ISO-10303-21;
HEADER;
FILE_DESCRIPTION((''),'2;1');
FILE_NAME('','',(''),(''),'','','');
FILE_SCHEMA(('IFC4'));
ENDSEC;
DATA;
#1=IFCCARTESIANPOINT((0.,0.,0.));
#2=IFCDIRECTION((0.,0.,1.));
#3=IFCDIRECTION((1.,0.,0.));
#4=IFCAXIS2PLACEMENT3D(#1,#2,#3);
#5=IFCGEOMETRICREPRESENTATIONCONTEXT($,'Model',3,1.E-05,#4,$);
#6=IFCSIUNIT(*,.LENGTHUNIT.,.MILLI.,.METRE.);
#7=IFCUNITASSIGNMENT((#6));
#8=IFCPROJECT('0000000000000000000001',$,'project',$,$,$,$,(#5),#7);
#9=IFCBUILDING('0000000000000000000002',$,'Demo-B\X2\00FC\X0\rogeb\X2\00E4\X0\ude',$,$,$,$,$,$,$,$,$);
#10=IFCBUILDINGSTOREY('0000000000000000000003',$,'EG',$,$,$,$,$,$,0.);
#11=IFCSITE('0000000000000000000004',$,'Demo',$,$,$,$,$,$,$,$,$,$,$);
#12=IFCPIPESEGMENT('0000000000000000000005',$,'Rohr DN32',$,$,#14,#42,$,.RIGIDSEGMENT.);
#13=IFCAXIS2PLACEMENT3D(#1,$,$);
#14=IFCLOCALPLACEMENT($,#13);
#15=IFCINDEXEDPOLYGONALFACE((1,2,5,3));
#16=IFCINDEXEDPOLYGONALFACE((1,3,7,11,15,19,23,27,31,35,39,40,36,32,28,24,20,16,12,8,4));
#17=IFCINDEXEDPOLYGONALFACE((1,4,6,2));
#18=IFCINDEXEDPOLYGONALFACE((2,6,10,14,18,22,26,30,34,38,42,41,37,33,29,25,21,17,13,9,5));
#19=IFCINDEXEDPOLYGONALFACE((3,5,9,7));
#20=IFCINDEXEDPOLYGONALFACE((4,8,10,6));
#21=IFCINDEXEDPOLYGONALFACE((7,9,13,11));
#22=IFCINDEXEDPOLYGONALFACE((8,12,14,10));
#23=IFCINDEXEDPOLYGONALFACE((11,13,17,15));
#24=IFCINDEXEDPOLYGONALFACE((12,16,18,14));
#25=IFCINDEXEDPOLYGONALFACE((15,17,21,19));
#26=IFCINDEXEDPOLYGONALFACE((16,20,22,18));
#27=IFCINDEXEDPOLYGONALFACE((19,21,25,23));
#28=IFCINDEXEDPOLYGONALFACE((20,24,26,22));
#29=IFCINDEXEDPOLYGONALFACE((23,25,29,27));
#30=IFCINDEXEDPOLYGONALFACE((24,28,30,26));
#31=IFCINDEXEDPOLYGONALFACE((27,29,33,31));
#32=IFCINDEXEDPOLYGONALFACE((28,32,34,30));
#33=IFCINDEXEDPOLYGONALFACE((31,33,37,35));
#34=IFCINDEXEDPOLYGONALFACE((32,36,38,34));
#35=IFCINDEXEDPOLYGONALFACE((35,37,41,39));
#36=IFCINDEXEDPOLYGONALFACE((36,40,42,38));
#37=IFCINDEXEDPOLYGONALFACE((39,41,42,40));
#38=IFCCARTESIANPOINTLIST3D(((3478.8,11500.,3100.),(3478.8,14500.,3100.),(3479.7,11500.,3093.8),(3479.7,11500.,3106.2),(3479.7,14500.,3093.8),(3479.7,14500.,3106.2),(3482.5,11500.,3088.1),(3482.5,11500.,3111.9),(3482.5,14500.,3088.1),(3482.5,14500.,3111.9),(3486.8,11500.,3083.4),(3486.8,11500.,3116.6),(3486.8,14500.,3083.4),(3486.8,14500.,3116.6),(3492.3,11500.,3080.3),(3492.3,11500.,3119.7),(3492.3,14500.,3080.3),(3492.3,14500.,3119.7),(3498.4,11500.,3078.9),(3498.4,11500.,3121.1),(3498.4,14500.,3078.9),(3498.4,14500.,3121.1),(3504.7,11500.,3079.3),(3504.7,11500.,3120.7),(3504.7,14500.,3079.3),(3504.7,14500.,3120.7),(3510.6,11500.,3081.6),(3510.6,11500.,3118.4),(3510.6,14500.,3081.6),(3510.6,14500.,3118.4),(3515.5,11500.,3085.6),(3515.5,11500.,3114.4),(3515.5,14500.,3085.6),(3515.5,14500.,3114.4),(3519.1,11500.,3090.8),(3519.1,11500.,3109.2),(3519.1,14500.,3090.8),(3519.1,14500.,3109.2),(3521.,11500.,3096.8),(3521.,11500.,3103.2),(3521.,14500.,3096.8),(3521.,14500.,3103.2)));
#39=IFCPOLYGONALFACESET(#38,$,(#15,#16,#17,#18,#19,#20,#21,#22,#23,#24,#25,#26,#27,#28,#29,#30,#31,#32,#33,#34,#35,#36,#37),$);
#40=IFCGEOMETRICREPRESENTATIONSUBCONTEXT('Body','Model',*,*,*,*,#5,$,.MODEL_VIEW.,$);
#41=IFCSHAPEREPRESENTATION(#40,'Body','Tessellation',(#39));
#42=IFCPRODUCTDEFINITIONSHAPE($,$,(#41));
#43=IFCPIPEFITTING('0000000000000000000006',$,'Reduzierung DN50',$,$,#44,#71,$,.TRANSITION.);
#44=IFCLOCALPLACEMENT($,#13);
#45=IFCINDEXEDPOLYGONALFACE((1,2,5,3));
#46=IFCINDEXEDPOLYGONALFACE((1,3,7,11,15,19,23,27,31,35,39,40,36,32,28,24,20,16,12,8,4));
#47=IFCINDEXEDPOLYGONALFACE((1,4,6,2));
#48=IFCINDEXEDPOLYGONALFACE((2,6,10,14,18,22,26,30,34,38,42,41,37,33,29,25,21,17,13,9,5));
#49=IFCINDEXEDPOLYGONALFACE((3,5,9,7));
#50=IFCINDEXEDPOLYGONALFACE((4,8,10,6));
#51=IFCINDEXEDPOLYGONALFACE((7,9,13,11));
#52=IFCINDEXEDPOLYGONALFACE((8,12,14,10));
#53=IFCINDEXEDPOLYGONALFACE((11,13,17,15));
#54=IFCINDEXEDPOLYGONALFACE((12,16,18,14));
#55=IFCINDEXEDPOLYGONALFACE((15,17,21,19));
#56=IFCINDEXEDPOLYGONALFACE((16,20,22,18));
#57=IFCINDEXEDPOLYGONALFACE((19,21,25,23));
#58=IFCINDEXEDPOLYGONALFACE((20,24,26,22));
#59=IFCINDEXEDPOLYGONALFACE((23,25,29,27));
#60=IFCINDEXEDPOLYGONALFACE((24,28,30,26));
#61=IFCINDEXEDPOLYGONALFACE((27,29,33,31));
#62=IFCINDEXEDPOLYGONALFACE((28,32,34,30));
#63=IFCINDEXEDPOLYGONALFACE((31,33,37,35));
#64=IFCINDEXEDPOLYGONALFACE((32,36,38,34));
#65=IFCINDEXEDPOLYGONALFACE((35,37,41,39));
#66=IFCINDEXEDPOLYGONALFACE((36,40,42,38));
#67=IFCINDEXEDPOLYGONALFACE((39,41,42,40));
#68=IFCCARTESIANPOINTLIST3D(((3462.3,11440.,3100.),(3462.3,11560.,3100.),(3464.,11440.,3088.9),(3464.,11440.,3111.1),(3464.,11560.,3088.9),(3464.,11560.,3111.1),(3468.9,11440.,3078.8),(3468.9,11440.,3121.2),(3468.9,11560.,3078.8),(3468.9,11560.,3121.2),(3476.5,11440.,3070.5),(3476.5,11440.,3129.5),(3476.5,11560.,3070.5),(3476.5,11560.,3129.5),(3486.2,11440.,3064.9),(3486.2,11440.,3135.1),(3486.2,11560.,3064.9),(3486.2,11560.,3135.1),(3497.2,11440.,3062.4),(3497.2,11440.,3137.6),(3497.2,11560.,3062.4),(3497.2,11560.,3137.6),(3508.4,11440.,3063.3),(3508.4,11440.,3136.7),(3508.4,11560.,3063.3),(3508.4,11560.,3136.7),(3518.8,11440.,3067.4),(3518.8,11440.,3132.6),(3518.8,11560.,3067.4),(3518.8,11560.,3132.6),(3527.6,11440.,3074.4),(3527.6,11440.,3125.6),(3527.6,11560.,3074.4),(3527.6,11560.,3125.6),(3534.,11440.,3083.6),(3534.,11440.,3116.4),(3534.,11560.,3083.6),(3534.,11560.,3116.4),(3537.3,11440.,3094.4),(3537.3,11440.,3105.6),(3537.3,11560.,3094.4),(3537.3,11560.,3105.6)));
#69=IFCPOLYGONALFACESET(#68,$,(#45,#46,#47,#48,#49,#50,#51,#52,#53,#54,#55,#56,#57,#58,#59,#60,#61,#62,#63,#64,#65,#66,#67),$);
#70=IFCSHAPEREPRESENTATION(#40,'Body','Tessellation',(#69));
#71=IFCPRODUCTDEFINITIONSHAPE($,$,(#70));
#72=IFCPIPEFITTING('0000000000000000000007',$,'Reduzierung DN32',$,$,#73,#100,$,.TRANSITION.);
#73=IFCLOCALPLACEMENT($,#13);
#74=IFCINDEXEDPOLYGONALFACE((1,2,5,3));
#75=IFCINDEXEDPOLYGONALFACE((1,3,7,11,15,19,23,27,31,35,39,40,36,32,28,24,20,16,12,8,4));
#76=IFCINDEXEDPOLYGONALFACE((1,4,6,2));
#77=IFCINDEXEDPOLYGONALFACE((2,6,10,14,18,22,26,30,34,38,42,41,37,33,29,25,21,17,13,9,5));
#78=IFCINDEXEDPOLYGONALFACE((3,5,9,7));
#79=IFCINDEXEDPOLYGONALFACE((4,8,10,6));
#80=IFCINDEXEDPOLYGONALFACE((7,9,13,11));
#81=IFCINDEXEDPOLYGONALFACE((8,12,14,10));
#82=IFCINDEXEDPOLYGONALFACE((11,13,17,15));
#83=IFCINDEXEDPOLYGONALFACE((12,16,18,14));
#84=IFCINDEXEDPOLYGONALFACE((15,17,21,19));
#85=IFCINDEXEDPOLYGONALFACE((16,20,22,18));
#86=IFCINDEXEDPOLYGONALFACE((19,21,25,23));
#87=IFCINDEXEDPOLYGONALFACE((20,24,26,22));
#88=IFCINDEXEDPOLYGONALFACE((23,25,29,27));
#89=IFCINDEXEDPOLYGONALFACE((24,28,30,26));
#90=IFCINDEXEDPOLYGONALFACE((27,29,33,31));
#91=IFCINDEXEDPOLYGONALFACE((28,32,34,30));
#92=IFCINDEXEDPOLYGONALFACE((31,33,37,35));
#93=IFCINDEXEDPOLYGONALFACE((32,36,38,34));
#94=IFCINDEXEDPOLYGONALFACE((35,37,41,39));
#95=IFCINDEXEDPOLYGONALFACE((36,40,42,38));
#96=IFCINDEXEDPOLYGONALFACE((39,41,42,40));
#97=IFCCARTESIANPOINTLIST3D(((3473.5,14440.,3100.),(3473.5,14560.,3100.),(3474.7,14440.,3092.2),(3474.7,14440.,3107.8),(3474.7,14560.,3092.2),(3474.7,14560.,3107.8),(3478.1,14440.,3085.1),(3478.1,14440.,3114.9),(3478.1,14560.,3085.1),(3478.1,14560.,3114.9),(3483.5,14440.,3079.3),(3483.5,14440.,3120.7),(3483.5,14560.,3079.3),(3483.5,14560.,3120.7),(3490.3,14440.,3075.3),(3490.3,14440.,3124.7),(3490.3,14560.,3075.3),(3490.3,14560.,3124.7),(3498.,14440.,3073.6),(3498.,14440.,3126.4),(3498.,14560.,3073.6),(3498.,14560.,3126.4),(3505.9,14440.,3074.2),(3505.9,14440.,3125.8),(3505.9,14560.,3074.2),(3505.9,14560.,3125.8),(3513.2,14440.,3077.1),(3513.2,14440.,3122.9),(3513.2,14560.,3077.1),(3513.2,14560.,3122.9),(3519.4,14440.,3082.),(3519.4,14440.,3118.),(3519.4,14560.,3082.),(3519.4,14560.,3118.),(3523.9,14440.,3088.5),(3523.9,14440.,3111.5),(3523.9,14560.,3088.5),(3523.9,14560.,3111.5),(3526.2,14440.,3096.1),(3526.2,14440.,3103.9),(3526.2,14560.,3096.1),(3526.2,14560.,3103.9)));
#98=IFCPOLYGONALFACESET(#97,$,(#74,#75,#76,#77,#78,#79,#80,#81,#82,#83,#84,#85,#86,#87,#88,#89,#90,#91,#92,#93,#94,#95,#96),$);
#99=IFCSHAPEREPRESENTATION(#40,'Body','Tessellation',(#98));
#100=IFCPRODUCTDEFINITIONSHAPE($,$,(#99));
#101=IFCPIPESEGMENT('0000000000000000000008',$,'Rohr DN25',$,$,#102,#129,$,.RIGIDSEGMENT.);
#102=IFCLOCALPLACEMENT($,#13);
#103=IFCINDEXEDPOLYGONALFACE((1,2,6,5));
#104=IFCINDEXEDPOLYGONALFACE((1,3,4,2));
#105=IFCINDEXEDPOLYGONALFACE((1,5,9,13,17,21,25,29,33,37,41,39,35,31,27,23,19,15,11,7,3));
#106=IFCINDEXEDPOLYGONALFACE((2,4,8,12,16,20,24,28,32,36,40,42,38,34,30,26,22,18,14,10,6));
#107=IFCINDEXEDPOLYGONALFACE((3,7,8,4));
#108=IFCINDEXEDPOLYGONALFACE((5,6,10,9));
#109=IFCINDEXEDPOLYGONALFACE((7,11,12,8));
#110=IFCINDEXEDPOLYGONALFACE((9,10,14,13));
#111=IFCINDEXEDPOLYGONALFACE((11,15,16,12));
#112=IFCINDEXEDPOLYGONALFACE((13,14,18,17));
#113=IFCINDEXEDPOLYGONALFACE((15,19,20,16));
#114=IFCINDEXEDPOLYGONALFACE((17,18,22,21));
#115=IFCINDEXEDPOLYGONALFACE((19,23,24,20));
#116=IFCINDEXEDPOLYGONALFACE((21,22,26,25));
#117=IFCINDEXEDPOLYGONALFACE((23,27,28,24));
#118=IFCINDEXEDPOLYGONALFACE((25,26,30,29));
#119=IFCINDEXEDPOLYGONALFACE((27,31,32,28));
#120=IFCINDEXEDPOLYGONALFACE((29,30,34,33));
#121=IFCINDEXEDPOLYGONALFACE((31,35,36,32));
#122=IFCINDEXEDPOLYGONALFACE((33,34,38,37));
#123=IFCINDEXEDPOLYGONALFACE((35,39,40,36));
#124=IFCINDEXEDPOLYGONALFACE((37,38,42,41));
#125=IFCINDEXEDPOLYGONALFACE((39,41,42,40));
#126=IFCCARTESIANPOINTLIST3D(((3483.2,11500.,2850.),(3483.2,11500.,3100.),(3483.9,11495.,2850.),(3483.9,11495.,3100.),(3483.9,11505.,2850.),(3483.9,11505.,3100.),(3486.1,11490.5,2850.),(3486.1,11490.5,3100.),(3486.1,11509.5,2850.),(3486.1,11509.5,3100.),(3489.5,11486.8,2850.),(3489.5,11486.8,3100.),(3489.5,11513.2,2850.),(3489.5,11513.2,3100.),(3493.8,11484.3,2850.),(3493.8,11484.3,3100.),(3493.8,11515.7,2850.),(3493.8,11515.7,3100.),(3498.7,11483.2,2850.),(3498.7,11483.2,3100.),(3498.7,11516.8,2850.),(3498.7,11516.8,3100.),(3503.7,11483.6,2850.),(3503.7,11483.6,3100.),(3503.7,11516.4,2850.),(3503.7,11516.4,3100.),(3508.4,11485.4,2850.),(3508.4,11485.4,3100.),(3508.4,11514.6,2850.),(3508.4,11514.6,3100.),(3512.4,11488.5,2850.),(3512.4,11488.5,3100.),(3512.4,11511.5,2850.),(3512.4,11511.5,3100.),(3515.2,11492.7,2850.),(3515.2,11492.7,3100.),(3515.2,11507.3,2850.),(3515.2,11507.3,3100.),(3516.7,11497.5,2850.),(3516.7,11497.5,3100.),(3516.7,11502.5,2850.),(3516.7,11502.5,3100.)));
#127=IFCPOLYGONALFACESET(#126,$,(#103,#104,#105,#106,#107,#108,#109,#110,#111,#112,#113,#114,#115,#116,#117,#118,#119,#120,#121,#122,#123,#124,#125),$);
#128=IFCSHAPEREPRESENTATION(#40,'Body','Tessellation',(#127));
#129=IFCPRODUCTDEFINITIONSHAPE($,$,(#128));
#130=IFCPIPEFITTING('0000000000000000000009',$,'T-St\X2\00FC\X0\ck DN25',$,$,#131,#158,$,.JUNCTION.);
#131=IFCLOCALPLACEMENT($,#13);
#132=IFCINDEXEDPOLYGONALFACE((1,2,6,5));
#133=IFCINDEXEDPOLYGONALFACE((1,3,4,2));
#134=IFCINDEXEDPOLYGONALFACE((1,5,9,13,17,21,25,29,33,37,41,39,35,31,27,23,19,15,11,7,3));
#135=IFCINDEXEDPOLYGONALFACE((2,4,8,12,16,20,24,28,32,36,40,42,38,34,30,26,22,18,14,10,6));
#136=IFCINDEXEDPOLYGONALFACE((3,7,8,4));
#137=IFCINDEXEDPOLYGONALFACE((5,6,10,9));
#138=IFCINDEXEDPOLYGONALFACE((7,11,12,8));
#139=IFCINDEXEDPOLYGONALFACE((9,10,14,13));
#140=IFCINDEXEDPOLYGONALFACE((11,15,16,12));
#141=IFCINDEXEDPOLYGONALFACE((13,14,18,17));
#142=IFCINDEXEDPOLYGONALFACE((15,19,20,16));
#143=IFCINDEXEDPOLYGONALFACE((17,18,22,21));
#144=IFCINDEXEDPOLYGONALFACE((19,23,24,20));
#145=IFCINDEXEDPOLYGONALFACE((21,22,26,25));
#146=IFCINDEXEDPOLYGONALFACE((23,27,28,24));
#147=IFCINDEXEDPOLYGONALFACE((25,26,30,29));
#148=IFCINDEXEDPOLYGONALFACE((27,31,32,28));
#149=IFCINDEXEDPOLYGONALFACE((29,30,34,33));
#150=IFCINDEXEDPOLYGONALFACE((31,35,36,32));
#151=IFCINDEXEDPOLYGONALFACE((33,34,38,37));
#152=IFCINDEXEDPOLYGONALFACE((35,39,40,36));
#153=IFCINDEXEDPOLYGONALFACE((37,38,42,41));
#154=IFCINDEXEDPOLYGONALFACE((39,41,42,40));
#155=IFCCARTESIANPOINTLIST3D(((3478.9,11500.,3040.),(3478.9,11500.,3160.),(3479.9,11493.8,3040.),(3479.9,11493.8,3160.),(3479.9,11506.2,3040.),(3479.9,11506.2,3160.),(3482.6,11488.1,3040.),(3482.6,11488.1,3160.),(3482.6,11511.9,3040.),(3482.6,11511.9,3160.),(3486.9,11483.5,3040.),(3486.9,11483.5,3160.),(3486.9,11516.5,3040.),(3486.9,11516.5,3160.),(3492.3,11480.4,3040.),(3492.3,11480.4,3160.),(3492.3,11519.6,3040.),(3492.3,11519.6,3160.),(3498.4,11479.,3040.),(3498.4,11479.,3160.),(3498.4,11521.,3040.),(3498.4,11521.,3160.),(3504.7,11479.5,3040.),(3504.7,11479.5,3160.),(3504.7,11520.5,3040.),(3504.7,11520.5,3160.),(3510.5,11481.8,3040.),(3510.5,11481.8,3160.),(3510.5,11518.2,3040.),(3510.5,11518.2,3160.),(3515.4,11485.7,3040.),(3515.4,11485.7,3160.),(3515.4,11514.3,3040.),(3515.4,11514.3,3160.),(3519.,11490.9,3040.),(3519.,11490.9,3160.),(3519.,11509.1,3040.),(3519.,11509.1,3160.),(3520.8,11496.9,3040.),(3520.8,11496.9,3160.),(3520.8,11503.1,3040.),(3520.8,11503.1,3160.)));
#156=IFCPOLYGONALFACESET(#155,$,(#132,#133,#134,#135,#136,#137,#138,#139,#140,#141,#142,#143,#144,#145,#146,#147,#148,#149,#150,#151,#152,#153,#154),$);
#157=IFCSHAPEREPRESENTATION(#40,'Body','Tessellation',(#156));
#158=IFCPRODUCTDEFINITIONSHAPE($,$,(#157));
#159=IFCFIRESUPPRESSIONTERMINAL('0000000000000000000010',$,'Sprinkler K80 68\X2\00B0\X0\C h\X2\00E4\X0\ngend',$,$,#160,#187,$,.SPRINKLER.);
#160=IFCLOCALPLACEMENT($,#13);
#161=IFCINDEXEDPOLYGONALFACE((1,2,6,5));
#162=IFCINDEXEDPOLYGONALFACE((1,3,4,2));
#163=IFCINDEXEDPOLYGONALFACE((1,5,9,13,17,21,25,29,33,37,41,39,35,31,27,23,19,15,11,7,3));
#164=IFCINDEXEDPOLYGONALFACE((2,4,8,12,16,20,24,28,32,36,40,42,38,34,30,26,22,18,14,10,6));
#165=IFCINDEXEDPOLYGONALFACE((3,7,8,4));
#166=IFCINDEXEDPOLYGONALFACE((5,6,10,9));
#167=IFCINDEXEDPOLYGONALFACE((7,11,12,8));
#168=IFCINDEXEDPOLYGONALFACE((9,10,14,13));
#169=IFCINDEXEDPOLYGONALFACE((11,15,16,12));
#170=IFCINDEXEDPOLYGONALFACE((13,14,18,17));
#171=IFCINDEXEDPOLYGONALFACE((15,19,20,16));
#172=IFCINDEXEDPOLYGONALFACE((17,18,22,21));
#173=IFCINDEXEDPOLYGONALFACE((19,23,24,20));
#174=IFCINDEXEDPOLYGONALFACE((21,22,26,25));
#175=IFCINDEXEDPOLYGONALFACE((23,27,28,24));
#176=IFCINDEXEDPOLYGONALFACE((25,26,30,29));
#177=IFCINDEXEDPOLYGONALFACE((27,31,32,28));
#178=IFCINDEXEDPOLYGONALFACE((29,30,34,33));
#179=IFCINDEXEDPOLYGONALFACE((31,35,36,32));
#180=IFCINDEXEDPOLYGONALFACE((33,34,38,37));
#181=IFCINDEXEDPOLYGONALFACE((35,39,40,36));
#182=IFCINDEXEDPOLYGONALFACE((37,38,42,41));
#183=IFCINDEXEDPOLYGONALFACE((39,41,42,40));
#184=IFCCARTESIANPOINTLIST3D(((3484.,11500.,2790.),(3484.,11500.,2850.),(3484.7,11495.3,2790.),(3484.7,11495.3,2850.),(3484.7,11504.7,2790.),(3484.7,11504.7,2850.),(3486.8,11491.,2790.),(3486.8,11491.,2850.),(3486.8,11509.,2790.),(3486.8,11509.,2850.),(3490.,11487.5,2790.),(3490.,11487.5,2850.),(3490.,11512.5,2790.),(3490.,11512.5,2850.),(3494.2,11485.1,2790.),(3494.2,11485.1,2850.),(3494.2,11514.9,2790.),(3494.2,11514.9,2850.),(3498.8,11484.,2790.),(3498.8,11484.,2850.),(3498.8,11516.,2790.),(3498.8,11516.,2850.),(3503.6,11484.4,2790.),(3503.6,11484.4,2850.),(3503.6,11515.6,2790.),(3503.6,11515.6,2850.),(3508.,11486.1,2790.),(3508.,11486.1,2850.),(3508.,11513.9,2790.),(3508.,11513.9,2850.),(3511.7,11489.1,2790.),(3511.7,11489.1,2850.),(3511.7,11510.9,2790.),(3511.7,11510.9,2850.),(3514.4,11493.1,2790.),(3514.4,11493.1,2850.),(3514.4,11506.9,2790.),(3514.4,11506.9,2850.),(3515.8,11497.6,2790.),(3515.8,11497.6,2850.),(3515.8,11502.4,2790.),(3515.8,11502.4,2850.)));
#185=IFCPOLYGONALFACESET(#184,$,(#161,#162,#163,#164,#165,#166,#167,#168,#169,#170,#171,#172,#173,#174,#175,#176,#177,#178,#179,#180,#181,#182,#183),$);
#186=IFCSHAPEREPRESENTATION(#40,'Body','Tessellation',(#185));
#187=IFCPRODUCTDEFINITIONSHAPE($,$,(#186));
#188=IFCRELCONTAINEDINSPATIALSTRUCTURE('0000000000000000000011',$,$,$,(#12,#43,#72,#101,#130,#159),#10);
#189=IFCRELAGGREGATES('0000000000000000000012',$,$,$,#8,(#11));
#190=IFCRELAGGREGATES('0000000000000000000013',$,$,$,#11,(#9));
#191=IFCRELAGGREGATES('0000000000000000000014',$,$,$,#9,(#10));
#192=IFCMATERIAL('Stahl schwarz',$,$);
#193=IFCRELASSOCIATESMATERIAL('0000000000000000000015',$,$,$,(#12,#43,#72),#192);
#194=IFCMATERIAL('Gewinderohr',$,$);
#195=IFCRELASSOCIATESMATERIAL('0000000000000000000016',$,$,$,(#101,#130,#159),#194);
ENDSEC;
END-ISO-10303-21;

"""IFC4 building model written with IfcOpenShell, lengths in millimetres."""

from ifc_helpers import new_model, si_unit, frame, origin_with_axes, place, context, subcontext, project, spatial, circle, extrude, material, element, save


model = new_model("IFC4")

# Units and contexts
model_context = context("Model", 3, precision=1e-05, world=origin_with_axes())
body_context = subcontext(model_context, "Body", "Model", "MODEL_VIEW")
ifc_project = project(units=[si_unit("LENGTHUNIT", "METRE", prefix="MILLI")], contexts=[model_context])

# Site, building, storey
site = spatial("IfcSite", under=ifc_project, Name="Demo")
building = spatial("IfcBuilding", under=site, Name="Demo-Bürogebäude")
storey = spatial("IfcBuildingStorey", under=building, Name="EG", Elevation=0.0)

# Pipe segment
ifc_material_1 = material(Name="Stahl schwarz")
pipe_segment_1_placement = place(None, frame((3500.0, 11500.0, 3100.0), z_axis=(0.0, 1.0, 0.0), x_axis=(-1.0, 0.0, 0.0)))
element("IfcPipeSegment", 1, at=pipe_segment_1_placement, inside=storey, material=ifc_material_1, Name="Rohr DN32", PredefinedType="RIGIDSEGMENT", context=body_context, shape_type="SweptSolid", body=[
    extrude(circle(Radius=21.2), origin_with_axes(), (0.0, 0.0, 1.0), 3000.0),
])

# Pipe fittings
pipe_fitting_1_placement = place(None, frame((3500.0, 11440.0, 3100.0), z_axis=(0.0, 1.0, 0.0), x_axis=(-1.0, 0.0, 0.0)))
element("IfcPipeFitting", 2, at=pipe_fitting_1_placement, inside=storey, material=ifc_material_1, Name="Reduzierung DN50", PredefinedType="TRANSITION", context=body_context, shape_type="SweptSolid", body=[
    extrude(circle(Radius=37.7), origin_with_axes(), (0.0, 0.0, 1.0), 120.0),
])
pipe_fitting_2_placement = place(None, frame((3500.0, 14440.0, 3100.0), z_axis=(0.0, 1.0, 0.0), x_axis=(-1.0, 0.0, 0.0)))
element("IfcPipeFitting", 3, at=pipe_fitting_2_placement, inside=storey, material=ifc_material_1, Name="Reduzierung DN32", PredefinedType="TRANSITION", context=body_context, shape_type="SweptSolid", body=[
    extrude(circle(Radius=26.5), origin_with_axes(), (0.0, 0.0, 1.0), 120.0),
])

# Pipe segment
ifc_material_2 = material(Name="Gewinderohr")
pipe_segment_2_placement = place(None, frame((3500.0, 11500.0, 3100.0), z_axis=(0.0, 0.0, -1.0), x_axis=(-1.0, 0.0, 0.0)))
element("IfcPipeSegment", 4, at=pipe_segment_2_placement, inside=storey, material=ifc_material_2, Name="Rohr DN25", PredefinedType="RIGIDSEGMENT", context=body_context, shape_type="SweptSolid", body=[
    extrude(circle(Radius=16.9), origin_with_axes(), (0.0, 0.0, 1.0), 250.0),
])

# Pipe fitting
pipe_fitting_3_placement = place(None, frame((3500.0, 11500.0, 3160.0), z_axis=(0.0, 0.0, -1.0), x_axis=(-1.0, 0.0, 0.0)))
element("IfcPipeFitting", 5, at=pipe_fitting_3_placement, inside=storey, material=ifc_material_2, Name="T-Stück DN25", PredefinedType="JUNCTION", context=body_context, shape_type="SweptSolid", body=[
    extrude(circle(Radius=21.1), origin_with_axes(), (0.0, 0.0, 1.0), 120.0),
])

# Fire suppression terminal
fire_suppression_terminal_1_placement = place(None, frame((3500.0, 11500.0, 2850.0), z_axis=(0.0, 0.0, -1.0), x_axis=(-1.0, 0.0, 0.0)))
element("IfcFireSuppressionTerminal", 6, at=fire_suppression_terminal_1_placement, inside=storey, material=ifc_material_2, Name="Sprinkler K80 68°C hängend", PredefinedType="SPRINKLER", context=body_context, shape_type="SweptSolid", body=[
    extrude(circle(Radius=16.0), origin_with_axes(), (0.0, 0.0, 1.0), 60.0),
])

save(model, "model.ifc")
